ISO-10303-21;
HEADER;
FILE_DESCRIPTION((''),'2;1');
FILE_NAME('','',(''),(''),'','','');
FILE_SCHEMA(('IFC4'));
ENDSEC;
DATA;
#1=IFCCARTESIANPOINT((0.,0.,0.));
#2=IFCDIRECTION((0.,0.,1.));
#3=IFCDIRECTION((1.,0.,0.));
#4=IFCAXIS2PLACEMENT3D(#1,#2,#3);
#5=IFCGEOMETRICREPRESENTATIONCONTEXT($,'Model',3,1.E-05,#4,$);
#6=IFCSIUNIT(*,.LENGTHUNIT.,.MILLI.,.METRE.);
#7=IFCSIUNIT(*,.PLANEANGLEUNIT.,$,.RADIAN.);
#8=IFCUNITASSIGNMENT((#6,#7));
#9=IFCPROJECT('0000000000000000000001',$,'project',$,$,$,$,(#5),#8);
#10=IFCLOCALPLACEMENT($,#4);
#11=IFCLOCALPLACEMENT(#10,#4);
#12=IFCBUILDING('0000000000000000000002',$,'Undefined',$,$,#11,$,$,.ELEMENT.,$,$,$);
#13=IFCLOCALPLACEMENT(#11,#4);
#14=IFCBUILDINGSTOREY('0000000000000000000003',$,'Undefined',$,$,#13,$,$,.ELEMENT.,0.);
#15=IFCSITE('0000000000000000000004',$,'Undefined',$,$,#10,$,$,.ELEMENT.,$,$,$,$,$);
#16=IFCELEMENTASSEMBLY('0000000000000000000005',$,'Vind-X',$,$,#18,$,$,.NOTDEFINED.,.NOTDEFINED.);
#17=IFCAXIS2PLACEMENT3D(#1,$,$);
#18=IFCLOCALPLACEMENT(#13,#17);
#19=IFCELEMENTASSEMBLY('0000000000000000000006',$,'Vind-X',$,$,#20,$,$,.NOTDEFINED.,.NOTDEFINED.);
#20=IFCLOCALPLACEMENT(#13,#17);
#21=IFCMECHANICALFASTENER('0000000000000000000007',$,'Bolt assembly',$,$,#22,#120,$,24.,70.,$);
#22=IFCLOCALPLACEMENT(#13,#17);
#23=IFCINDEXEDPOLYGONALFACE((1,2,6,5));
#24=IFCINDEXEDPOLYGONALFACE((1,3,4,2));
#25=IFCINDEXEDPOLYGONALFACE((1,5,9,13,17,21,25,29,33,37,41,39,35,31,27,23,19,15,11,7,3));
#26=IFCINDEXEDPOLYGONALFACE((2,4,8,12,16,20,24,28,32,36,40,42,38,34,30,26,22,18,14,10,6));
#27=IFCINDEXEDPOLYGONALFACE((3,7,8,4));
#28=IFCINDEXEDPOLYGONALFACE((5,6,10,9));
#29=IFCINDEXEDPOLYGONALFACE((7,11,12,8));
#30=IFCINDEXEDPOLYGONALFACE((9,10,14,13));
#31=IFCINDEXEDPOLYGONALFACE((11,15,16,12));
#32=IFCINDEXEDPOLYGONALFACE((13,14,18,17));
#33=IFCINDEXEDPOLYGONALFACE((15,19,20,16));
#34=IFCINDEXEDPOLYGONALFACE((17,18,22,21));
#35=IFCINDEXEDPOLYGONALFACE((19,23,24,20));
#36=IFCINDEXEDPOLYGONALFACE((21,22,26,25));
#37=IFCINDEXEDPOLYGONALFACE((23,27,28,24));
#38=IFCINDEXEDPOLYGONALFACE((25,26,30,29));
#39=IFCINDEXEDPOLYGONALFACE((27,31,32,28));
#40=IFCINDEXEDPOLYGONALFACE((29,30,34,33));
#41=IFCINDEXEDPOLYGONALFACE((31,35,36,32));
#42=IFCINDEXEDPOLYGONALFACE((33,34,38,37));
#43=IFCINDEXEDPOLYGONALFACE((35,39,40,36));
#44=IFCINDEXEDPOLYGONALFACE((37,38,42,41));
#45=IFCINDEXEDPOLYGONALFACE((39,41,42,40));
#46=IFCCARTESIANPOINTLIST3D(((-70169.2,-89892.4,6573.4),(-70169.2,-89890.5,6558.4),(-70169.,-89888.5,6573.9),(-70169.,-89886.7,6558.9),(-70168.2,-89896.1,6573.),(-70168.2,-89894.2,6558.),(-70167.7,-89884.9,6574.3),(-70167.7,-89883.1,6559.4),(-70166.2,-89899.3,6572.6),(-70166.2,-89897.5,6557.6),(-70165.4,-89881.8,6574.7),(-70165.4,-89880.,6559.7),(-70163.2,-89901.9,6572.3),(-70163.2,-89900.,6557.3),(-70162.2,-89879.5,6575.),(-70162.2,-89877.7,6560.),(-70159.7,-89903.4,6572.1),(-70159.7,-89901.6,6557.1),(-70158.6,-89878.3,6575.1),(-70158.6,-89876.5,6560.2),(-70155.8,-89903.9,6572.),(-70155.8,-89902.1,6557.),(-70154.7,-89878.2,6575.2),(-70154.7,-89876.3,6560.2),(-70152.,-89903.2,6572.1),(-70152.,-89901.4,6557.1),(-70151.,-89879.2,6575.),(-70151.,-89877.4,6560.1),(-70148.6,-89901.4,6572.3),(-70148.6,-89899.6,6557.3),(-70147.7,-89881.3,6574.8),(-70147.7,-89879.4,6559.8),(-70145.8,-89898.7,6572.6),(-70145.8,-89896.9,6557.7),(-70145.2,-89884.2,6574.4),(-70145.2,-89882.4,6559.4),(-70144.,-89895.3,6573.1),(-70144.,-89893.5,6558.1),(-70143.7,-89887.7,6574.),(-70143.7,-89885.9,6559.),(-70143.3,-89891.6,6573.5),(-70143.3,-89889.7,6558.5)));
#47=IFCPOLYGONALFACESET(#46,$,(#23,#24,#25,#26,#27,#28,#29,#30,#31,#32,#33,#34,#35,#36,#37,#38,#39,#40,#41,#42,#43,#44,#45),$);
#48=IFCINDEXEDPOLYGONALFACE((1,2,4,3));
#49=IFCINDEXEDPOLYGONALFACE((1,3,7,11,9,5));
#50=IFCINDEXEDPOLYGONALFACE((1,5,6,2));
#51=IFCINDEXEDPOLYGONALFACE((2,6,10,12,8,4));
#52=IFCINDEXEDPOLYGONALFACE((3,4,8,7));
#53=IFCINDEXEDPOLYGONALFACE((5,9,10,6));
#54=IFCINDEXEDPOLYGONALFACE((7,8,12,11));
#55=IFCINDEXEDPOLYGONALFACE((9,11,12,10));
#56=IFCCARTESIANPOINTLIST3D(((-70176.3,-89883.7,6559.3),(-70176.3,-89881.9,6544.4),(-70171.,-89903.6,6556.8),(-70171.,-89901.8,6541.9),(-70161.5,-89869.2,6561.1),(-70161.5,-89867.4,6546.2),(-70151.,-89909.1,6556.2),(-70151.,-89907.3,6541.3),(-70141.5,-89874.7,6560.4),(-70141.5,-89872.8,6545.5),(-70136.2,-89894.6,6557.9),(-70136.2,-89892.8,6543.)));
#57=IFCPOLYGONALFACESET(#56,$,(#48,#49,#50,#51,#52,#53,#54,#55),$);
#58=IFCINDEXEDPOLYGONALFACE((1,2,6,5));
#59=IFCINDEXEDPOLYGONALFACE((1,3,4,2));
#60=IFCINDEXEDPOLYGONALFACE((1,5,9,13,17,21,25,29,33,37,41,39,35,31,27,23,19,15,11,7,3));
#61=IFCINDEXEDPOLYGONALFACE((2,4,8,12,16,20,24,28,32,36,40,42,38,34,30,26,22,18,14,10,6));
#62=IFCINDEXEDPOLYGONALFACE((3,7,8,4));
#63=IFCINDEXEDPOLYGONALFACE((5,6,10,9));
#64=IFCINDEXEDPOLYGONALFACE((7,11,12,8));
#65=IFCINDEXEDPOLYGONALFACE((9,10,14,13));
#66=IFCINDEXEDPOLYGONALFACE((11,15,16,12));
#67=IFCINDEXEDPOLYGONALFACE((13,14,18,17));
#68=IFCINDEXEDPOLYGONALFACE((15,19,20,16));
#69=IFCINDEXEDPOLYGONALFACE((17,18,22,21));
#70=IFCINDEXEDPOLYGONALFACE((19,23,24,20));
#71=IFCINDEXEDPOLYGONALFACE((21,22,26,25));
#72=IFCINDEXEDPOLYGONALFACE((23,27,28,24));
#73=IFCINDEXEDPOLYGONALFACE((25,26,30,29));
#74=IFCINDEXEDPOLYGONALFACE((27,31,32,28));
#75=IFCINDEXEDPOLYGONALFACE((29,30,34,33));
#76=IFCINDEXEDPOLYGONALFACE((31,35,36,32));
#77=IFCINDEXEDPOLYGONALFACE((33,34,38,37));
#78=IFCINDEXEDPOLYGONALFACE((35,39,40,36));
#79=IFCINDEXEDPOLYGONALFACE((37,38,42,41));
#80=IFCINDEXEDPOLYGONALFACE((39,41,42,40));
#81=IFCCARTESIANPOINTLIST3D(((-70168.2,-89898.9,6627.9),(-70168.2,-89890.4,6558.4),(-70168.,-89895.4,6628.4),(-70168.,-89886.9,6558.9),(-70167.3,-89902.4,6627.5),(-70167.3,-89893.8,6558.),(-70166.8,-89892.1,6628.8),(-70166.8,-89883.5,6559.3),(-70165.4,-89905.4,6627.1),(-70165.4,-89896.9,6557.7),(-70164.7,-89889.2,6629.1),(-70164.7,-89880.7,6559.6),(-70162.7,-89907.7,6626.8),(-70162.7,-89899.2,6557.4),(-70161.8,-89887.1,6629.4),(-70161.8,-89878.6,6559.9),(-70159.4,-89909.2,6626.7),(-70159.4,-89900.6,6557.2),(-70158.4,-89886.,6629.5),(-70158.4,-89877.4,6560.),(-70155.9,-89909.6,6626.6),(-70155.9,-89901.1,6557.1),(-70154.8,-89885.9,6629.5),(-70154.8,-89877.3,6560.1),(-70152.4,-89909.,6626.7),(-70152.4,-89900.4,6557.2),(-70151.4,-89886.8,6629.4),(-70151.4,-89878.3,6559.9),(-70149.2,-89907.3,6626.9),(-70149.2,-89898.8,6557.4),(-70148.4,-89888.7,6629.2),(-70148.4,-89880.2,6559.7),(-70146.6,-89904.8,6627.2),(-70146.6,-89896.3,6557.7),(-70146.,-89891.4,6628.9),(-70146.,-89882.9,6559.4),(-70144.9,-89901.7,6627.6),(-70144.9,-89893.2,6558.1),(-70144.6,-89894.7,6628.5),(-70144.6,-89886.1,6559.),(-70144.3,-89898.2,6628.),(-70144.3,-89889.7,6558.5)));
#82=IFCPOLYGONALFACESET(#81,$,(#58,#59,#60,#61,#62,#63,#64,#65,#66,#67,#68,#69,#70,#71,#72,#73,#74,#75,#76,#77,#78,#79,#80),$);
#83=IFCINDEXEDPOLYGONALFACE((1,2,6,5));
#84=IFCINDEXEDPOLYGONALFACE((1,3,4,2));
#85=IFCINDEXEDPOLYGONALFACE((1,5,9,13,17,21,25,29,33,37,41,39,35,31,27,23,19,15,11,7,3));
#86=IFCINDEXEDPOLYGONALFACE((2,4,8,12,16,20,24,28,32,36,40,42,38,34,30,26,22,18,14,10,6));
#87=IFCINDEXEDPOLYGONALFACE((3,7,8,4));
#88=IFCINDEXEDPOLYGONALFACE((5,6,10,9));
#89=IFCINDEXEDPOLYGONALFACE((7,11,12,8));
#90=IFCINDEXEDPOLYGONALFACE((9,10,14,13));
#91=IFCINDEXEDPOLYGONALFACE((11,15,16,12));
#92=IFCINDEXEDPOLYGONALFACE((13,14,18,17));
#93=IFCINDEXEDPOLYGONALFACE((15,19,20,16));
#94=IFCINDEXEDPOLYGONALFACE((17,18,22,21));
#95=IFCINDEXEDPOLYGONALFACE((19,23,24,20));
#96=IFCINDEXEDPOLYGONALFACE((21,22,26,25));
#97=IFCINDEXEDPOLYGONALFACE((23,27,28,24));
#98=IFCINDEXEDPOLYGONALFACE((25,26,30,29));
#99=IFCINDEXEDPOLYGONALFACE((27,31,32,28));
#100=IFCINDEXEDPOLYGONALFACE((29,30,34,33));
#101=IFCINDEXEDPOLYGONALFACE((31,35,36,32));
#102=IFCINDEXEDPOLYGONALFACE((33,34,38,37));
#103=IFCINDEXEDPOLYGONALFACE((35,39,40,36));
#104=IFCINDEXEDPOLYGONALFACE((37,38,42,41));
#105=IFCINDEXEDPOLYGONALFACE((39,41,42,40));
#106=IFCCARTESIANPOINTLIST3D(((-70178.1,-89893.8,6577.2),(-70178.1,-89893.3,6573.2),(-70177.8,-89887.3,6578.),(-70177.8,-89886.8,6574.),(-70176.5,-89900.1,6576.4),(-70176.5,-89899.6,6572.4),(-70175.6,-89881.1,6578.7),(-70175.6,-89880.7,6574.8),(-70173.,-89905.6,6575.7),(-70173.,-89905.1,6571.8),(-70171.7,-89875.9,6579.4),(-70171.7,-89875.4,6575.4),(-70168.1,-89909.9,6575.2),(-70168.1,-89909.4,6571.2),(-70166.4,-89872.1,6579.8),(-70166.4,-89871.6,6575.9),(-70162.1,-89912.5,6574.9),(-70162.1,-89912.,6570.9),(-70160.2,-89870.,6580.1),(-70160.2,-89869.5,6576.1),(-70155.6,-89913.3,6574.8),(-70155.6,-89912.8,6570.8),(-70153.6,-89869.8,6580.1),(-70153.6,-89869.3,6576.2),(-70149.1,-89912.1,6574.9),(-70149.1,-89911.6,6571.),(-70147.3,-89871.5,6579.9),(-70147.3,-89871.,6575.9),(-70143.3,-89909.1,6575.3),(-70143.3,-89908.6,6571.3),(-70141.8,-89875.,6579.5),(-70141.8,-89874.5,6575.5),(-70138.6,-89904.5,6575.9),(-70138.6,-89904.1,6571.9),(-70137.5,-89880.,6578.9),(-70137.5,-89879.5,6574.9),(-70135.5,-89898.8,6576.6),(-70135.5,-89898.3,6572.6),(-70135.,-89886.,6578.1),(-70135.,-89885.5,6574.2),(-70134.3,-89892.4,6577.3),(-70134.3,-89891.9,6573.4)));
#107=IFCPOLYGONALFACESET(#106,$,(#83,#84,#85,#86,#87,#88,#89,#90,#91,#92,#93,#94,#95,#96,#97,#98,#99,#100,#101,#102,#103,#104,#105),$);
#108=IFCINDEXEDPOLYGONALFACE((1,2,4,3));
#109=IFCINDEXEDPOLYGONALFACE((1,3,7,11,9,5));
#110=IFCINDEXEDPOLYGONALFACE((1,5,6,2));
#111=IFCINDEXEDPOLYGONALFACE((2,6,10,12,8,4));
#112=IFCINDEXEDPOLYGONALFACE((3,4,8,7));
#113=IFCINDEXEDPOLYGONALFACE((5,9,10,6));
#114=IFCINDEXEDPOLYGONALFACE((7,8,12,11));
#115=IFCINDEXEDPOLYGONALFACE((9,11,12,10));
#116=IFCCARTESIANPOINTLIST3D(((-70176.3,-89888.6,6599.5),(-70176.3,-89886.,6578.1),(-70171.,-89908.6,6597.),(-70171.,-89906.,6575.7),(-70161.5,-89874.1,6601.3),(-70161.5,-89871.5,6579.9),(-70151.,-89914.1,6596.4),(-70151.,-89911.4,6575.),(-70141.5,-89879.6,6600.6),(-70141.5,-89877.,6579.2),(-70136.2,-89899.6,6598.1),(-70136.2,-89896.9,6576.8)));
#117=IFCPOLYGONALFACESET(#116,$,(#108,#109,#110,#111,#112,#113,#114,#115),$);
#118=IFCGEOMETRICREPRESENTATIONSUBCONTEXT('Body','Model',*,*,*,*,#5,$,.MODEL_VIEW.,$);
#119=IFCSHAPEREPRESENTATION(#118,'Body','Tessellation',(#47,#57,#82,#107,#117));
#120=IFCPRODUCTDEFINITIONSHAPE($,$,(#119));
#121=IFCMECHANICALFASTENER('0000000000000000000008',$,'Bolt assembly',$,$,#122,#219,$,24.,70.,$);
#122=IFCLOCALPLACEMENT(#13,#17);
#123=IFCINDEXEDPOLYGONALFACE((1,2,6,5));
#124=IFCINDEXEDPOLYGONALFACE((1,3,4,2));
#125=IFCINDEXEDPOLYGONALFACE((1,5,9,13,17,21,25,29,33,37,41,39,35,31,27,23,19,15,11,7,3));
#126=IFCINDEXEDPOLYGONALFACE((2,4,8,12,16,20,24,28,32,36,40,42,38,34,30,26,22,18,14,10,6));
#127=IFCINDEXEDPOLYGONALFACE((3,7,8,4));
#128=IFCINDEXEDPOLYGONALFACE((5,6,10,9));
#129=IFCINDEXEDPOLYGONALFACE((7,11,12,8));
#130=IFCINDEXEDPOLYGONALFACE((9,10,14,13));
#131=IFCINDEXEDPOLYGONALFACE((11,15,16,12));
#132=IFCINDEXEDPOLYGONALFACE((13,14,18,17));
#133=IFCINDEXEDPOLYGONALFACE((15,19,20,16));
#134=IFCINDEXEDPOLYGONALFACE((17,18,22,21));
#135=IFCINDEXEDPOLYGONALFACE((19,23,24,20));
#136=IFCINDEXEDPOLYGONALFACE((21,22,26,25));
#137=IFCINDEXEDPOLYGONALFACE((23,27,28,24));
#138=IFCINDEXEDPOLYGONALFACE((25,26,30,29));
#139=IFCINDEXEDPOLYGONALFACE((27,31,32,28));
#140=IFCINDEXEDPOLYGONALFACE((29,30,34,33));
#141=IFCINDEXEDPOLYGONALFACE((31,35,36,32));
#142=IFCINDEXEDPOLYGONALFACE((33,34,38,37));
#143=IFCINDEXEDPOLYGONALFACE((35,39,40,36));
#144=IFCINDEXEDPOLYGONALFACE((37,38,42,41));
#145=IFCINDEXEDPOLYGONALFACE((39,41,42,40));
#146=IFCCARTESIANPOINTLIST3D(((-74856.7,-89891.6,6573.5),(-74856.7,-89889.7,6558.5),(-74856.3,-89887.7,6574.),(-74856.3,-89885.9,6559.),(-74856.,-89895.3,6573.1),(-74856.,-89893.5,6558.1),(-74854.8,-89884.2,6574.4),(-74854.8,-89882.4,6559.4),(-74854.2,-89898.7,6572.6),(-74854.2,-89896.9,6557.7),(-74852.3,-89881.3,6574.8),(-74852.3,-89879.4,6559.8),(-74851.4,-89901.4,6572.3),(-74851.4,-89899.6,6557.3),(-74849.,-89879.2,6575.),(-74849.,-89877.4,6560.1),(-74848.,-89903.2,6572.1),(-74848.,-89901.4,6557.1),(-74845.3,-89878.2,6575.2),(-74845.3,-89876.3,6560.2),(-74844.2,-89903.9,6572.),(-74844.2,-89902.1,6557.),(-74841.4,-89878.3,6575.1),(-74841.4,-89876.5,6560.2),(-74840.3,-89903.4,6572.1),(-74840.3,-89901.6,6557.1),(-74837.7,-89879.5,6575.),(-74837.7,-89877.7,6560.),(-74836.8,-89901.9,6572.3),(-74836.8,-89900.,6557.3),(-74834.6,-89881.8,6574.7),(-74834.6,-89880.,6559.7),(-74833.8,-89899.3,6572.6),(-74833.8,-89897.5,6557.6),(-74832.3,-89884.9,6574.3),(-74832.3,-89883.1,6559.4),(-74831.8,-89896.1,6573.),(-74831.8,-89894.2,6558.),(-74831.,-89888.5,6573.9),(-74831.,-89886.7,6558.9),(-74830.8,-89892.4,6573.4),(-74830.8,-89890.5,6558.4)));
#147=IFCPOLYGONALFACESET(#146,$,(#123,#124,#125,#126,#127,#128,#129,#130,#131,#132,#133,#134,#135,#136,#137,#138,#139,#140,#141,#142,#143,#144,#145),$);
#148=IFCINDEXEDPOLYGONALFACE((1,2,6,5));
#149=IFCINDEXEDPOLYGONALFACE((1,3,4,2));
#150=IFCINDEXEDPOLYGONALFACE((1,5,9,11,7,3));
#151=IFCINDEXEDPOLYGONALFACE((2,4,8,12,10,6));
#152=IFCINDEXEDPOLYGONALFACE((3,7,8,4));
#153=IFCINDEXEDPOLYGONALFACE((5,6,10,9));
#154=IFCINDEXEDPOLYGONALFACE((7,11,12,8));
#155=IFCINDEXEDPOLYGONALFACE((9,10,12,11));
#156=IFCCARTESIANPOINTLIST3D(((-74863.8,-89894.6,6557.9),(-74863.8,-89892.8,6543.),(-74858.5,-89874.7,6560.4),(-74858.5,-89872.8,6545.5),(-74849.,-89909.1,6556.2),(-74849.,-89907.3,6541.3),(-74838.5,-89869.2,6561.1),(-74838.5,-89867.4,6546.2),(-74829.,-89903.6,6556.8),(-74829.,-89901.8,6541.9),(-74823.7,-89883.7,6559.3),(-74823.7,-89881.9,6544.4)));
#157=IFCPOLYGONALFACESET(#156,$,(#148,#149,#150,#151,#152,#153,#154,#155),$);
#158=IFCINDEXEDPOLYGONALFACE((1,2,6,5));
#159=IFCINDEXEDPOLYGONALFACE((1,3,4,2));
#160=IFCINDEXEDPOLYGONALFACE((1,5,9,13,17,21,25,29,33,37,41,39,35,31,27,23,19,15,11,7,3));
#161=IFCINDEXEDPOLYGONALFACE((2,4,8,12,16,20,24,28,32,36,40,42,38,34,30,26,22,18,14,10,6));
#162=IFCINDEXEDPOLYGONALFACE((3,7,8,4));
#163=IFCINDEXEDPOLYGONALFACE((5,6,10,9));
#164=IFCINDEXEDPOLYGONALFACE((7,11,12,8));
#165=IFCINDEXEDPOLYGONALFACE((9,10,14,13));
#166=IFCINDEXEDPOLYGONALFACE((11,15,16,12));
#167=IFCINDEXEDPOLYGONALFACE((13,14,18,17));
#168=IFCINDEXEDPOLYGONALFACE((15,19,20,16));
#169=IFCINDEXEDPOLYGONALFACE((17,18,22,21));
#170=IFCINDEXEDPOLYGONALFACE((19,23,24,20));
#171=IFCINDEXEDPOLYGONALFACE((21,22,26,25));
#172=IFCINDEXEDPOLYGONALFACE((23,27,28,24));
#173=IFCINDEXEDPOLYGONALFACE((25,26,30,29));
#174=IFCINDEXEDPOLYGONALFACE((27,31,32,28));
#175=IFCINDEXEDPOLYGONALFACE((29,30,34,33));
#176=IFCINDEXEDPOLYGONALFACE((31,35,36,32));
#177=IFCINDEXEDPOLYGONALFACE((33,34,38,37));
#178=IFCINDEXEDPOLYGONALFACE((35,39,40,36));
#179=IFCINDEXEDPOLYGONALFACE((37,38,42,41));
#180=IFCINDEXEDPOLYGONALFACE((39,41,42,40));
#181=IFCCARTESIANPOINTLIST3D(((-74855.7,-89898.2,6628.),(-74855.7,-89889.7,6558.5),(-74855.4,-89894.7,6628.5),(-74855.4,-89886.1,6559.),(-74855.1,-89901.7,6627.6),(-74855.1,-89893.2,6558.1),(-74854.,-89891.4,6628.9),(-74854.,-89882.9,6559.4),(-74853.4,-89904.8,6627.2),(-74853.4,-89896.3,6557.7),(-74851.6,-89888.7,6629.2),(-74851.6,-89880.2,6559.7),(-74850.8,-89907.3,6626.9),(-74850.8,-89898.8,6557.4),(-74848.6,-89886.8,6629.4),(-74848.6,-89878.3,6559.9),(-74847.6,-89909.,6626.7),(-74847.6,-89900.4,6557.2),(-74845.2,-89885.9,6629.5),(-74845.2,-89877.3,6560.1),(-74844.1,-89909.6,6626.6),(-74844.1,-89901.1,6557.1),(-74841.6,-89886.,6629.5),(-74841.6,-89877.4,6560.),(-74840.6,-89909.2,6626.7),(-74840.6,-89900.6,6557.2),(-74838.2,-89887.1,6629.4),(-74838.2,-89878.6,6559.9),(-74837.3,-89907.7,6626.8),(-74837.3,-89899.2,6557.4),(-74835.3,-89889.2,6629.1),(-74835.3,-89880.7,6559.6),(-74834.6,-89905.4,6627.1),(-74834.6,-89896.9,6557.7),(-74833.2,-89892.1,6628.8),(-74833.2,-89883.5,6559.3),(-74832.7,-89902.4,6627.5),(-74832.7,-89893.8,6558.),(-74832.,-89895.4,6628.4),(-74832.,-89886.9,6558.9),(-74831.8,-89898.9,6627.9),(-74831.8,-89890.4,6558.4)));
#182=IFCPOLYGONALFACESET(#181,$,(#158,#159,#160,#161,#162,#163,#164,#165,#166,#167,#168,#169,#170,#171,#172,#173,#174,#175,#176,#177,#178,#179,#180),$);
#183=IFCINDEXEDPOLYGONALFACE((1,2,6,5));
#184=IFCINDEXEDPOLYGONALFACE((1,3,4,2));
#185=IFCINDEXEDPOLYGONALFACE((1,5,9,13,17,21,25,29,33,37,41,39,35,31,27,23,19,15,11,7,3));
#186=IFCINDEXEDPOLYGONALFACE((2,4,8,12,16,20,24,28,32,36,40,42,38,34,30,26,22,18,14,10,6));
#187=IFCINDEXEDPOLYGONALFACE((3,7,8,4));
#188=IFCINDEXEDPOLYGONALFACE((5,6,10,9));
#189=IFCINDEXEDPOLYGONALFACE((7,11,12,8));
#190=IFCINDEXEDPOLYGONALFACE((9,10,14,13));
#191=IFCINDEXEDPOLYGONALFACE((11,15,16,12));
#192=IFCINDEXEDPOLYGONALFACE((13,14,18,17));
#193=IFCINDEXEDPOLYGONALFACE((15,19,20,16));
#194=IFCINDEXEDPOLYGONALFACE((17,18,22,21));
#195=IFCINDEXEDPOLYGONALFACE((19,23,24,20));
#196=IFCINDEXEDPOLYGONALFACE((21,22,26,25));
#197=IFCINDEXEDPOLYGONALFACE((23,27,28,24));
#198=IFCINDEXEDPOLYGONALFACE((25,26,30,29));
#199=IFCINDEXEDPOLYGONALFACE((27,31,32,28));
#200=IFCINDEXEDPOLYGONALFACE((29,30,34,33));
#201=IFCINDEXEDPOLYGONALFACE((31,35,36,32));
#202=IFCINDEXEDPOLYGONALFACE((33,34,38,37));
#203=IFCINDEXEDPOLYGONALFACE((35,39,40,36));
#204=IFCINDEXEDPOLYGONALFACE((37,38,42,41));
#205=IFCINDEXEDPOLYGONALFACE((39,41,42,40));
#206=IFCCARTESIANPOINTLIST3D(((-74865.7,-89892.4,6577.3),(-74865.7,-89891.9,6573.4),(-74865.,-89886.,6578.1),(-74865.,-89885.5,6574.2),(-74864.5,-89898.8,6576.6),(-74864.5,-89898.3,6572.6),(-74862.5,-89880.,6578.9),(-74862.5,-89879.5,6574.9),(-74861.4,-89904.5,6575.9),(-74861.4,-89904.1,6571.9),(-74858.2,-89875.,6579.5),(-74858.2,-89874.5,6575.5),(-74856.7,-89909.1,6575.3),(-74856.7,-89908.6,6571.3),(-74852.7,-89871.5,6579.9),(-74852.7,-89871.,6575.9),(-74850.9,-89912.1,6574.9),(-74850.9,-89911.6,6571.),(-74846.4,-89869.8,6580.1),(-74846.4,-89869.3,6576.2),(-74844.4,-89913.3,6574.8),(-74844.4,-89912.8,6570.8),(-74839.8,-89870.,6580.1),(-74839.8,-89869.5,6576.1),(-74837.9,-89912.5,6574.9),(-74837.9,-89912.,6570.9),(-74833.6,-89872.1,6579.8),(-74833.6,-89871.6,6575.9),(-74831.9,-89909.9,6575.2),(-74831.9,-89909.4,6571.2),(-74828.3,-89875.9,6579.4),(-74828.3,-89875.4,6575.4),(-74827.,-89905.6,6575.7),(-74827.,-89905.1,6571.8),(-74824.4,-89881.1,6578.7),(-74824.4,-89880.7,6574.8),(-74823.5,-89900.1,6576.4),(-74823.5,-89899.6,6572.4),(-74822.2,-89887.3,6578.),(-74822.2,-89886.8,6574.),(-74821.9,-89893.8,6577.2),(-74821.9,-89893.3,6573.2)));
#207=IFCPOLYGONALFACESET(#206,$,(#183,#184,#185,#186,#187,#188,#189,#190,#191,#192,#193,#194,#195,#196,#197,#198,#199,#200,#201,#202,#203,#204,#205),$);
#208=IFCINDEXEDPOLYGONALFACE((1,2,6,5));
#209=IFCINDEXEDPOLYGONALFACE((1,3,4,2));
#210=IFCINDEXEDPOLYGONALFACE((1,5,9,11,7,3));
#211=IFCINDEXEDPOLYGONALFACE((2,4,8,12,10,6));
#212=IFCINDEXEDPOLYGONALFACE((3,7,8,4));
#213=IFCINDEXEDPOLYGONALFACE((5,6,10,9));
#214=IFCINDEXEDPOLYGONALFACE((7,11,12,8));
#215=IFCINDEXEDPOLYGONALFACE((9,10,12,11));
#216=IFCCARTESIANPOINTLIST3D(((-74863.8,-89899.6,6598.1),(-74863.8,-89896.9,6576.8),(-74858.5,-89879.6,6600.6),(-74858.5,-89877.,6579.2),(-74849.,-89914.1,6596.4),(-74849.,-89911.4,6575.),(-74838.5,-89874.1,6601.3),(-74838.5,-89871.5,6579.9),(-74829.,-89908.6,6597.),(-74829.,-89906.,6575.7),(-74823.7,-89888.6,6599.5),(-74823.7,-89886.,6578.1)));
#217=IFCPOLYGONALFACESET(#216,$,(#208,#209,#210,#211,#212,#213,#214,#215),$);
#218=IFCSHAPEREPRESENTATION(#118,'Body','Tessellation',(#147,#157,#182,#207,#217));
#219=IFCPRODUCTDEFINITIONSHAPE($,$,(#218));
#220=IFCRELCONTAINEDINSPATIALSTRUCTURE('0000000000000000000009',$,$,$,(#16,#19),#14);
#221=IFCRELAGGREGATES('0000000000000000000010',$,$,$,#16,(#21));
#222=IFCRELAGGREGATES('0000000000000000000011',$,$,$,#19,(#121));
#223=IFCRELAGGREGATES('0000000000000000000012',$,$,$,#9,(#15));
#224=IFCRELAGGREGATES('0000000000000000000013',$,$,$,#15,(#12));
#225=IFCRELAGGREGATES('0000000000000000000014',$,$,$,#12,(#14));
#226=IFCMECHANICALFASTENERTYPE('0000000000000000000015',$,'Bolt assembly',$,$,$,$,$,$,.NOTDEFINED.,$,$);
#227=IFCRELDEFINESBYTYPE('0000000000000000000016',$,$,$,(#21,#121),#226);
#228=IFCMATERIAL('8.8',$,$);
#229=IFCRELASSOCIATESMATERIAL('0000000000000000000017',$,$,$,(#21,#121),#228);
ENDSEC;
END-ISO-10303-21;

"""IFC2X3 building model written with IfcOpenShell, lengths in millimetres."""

from ifc_helpers import new_model, si_unit, frame, origin_with_axes, origin_2d_with_axis, place, context, subcontext, project, spatial, polyline, circle, outline, extrude, source, transform, mapped, material, type_object, element, aggregate, save


model = new_model("IFC2X3")

# Units and contexts
model_context = context("Model", 3, precision=1e-05, world=origin_with_axes())
body_context = subcontext(model_context, "Body", "Model", "MODEL_VIEW")
ifc_project = project(units=[si_unit("LENGTHUNIT", "METRE", prefix="MILLI"), si_unit("PLANEANGLEUNIT", "RADIAN")], contexts=[model_context])

# Site, building, storey
site_placement = place(None, origin_with_axes())
site = spatial("IfcSite", under=ifc_project, at=site_placement, Name="Undefined", CompositionType="ELEMENT")
building_placement = place(site_placement, origin_with_axes())
building = spatial("IfcBuilding", under=site, at=building_placement, Name="Undefined", CompositionType="ELEMENT")
storey_placement = place(building_placement, origin_with_axes())
storey = spatial("IfcBuildingStorey", under=building, at=storey_placement, Name="Undefined", CompositionType="ELEMENT", Elevation=0.0)

# Element assemblies
assembly_1_placement = place(storey_placement, origin_with_axes())
assembly_1 = element("IfcElementAssembly", 1, at=assembly_1_placement, inside=storey, Name="Vind-X", AssemblyPlace="NOTDEFINED", PredefinedType="NOTDEFINED")
assembly_2_placement = place(storey_placement, origin_with_axes())
assembly_2 = element("IfcElementAssembly", 2, at=assembly_2_placement, inside=storey, Name="Vind-X", AssemblyPlace="NOTDEFINED", PredefinedType="NOTDEFINED")

# Mechanical fasteners
ifc_material_1 = material(Name="8.8")
mechanical_fastener_type = type_object("IfcMechanicalFastenerType", Name="Bolt assembly")
shared_shape_1 = source(origin_with_axes(), body_context, "Body", "SweptSolid", [
    extrude(circle(Radius=13.0, at=origin_2d_with_axis()), frame((0.0, 0.0, 0.0), z_axis=(0.0, 1.0, 0.0), x_axis=(1.0, 0.0, 0.0)), (0.0, 0.0, 1.0), 15.1),
    extrude(outline(polyline([(18.0, -10.4), (18.0, 10.4), (0.0, 20.8), (-18.0, 10.4), (-18.0, -10.4), (0.0, -20.8), (18.0, -10.4)])), frame((0.0, -15.0, 0.0), z_axis=(0.0, 1.0, 0.0), x_axis=(1.0, 0.0, 0.0)), (0.0, 0.0, 1.0), 15.0),
    extrude(circle(Radius=12.0, at=origin_2d_with_axis()), frame((0.0, 0.0, 0.0), z_axis=(0.0, 1.0, 0.0), x_axis=(1.0, 0.0, 0.0)), (0.0, 0.0, 1.0), 70.0),
    extrude(circle(Radius=22.0, at=origin_2d_with_axis()), frame((0.0, 15.0, 0.0), z_axis=(0.0, 1.0, 0.0), x_axis=(1.0, 0.0, 0.0)), (0.0, 0.0, 1.0), 4.0),
    extrude(outline(polyline([(18.0, -10.4), (18.0, 10.4), (0.0, 20.8), (-18.0, 10.4), (-18.0, -10.4), (0.0, -20.8), (18.0, -10.4)])), frame((0.0, 19.0, 0.0), z_axis=(0.0, 1.0, 0.0), x_axis=(1.0, 0.0, 0.0)), (0.0, 0.0, 1.0), 21.5),
])
mechanical_fastener_1_placement = place(assembly_1_placement, frame((-70156.2, -89889.2, 6558.6), z_axis=(0.711592, 0.697356, 0.085625), x_axis=(-0.702593, 0.706288, 0.086721)))
mechanical_fastener_1 = element("IfcMechanicalFastener", 3, at=mechanical_fastener_1_placement, type_object=mechanical_fastener_type, material=ifc_material_1, Name="Bolt assembly", NominalDiameter=24.0, NominalLength=70.0, context=body_context, shape_type="MappedRepresentation", body=[
    mapped(shared_shape_1, transform((0.0, 0.0, 0.0))),
])
aggregate(assembly_1, [mechanical_fastener_1])
mechanical_fastener_2_placement = place(assembly_2_placement, frame((-74843.8, -89889.2, 6558.6), z_axis=(0.711592, -0.697356, -0.085625), x_axis=(0.702593, 0.706288, 0.086721)))
mechanical_fastener_2 = element("IfcMechanicalFastener", 4, at=mechanical_fastener_2_placement, type_object=mechanical_fastener_type, material=ifc_material_1, Name="Bolt assembly", NominalDiameter=24.0, NominalLength=70.0, context=body_context, shape_type="MappedRepresentation", body=[
    mapped(shared_shape_1, transform((0.0, 0.0, 0.0))),
])
aggregate(assembly_2, [mechanical_fastener_2])

save(model, "model.ifc")
